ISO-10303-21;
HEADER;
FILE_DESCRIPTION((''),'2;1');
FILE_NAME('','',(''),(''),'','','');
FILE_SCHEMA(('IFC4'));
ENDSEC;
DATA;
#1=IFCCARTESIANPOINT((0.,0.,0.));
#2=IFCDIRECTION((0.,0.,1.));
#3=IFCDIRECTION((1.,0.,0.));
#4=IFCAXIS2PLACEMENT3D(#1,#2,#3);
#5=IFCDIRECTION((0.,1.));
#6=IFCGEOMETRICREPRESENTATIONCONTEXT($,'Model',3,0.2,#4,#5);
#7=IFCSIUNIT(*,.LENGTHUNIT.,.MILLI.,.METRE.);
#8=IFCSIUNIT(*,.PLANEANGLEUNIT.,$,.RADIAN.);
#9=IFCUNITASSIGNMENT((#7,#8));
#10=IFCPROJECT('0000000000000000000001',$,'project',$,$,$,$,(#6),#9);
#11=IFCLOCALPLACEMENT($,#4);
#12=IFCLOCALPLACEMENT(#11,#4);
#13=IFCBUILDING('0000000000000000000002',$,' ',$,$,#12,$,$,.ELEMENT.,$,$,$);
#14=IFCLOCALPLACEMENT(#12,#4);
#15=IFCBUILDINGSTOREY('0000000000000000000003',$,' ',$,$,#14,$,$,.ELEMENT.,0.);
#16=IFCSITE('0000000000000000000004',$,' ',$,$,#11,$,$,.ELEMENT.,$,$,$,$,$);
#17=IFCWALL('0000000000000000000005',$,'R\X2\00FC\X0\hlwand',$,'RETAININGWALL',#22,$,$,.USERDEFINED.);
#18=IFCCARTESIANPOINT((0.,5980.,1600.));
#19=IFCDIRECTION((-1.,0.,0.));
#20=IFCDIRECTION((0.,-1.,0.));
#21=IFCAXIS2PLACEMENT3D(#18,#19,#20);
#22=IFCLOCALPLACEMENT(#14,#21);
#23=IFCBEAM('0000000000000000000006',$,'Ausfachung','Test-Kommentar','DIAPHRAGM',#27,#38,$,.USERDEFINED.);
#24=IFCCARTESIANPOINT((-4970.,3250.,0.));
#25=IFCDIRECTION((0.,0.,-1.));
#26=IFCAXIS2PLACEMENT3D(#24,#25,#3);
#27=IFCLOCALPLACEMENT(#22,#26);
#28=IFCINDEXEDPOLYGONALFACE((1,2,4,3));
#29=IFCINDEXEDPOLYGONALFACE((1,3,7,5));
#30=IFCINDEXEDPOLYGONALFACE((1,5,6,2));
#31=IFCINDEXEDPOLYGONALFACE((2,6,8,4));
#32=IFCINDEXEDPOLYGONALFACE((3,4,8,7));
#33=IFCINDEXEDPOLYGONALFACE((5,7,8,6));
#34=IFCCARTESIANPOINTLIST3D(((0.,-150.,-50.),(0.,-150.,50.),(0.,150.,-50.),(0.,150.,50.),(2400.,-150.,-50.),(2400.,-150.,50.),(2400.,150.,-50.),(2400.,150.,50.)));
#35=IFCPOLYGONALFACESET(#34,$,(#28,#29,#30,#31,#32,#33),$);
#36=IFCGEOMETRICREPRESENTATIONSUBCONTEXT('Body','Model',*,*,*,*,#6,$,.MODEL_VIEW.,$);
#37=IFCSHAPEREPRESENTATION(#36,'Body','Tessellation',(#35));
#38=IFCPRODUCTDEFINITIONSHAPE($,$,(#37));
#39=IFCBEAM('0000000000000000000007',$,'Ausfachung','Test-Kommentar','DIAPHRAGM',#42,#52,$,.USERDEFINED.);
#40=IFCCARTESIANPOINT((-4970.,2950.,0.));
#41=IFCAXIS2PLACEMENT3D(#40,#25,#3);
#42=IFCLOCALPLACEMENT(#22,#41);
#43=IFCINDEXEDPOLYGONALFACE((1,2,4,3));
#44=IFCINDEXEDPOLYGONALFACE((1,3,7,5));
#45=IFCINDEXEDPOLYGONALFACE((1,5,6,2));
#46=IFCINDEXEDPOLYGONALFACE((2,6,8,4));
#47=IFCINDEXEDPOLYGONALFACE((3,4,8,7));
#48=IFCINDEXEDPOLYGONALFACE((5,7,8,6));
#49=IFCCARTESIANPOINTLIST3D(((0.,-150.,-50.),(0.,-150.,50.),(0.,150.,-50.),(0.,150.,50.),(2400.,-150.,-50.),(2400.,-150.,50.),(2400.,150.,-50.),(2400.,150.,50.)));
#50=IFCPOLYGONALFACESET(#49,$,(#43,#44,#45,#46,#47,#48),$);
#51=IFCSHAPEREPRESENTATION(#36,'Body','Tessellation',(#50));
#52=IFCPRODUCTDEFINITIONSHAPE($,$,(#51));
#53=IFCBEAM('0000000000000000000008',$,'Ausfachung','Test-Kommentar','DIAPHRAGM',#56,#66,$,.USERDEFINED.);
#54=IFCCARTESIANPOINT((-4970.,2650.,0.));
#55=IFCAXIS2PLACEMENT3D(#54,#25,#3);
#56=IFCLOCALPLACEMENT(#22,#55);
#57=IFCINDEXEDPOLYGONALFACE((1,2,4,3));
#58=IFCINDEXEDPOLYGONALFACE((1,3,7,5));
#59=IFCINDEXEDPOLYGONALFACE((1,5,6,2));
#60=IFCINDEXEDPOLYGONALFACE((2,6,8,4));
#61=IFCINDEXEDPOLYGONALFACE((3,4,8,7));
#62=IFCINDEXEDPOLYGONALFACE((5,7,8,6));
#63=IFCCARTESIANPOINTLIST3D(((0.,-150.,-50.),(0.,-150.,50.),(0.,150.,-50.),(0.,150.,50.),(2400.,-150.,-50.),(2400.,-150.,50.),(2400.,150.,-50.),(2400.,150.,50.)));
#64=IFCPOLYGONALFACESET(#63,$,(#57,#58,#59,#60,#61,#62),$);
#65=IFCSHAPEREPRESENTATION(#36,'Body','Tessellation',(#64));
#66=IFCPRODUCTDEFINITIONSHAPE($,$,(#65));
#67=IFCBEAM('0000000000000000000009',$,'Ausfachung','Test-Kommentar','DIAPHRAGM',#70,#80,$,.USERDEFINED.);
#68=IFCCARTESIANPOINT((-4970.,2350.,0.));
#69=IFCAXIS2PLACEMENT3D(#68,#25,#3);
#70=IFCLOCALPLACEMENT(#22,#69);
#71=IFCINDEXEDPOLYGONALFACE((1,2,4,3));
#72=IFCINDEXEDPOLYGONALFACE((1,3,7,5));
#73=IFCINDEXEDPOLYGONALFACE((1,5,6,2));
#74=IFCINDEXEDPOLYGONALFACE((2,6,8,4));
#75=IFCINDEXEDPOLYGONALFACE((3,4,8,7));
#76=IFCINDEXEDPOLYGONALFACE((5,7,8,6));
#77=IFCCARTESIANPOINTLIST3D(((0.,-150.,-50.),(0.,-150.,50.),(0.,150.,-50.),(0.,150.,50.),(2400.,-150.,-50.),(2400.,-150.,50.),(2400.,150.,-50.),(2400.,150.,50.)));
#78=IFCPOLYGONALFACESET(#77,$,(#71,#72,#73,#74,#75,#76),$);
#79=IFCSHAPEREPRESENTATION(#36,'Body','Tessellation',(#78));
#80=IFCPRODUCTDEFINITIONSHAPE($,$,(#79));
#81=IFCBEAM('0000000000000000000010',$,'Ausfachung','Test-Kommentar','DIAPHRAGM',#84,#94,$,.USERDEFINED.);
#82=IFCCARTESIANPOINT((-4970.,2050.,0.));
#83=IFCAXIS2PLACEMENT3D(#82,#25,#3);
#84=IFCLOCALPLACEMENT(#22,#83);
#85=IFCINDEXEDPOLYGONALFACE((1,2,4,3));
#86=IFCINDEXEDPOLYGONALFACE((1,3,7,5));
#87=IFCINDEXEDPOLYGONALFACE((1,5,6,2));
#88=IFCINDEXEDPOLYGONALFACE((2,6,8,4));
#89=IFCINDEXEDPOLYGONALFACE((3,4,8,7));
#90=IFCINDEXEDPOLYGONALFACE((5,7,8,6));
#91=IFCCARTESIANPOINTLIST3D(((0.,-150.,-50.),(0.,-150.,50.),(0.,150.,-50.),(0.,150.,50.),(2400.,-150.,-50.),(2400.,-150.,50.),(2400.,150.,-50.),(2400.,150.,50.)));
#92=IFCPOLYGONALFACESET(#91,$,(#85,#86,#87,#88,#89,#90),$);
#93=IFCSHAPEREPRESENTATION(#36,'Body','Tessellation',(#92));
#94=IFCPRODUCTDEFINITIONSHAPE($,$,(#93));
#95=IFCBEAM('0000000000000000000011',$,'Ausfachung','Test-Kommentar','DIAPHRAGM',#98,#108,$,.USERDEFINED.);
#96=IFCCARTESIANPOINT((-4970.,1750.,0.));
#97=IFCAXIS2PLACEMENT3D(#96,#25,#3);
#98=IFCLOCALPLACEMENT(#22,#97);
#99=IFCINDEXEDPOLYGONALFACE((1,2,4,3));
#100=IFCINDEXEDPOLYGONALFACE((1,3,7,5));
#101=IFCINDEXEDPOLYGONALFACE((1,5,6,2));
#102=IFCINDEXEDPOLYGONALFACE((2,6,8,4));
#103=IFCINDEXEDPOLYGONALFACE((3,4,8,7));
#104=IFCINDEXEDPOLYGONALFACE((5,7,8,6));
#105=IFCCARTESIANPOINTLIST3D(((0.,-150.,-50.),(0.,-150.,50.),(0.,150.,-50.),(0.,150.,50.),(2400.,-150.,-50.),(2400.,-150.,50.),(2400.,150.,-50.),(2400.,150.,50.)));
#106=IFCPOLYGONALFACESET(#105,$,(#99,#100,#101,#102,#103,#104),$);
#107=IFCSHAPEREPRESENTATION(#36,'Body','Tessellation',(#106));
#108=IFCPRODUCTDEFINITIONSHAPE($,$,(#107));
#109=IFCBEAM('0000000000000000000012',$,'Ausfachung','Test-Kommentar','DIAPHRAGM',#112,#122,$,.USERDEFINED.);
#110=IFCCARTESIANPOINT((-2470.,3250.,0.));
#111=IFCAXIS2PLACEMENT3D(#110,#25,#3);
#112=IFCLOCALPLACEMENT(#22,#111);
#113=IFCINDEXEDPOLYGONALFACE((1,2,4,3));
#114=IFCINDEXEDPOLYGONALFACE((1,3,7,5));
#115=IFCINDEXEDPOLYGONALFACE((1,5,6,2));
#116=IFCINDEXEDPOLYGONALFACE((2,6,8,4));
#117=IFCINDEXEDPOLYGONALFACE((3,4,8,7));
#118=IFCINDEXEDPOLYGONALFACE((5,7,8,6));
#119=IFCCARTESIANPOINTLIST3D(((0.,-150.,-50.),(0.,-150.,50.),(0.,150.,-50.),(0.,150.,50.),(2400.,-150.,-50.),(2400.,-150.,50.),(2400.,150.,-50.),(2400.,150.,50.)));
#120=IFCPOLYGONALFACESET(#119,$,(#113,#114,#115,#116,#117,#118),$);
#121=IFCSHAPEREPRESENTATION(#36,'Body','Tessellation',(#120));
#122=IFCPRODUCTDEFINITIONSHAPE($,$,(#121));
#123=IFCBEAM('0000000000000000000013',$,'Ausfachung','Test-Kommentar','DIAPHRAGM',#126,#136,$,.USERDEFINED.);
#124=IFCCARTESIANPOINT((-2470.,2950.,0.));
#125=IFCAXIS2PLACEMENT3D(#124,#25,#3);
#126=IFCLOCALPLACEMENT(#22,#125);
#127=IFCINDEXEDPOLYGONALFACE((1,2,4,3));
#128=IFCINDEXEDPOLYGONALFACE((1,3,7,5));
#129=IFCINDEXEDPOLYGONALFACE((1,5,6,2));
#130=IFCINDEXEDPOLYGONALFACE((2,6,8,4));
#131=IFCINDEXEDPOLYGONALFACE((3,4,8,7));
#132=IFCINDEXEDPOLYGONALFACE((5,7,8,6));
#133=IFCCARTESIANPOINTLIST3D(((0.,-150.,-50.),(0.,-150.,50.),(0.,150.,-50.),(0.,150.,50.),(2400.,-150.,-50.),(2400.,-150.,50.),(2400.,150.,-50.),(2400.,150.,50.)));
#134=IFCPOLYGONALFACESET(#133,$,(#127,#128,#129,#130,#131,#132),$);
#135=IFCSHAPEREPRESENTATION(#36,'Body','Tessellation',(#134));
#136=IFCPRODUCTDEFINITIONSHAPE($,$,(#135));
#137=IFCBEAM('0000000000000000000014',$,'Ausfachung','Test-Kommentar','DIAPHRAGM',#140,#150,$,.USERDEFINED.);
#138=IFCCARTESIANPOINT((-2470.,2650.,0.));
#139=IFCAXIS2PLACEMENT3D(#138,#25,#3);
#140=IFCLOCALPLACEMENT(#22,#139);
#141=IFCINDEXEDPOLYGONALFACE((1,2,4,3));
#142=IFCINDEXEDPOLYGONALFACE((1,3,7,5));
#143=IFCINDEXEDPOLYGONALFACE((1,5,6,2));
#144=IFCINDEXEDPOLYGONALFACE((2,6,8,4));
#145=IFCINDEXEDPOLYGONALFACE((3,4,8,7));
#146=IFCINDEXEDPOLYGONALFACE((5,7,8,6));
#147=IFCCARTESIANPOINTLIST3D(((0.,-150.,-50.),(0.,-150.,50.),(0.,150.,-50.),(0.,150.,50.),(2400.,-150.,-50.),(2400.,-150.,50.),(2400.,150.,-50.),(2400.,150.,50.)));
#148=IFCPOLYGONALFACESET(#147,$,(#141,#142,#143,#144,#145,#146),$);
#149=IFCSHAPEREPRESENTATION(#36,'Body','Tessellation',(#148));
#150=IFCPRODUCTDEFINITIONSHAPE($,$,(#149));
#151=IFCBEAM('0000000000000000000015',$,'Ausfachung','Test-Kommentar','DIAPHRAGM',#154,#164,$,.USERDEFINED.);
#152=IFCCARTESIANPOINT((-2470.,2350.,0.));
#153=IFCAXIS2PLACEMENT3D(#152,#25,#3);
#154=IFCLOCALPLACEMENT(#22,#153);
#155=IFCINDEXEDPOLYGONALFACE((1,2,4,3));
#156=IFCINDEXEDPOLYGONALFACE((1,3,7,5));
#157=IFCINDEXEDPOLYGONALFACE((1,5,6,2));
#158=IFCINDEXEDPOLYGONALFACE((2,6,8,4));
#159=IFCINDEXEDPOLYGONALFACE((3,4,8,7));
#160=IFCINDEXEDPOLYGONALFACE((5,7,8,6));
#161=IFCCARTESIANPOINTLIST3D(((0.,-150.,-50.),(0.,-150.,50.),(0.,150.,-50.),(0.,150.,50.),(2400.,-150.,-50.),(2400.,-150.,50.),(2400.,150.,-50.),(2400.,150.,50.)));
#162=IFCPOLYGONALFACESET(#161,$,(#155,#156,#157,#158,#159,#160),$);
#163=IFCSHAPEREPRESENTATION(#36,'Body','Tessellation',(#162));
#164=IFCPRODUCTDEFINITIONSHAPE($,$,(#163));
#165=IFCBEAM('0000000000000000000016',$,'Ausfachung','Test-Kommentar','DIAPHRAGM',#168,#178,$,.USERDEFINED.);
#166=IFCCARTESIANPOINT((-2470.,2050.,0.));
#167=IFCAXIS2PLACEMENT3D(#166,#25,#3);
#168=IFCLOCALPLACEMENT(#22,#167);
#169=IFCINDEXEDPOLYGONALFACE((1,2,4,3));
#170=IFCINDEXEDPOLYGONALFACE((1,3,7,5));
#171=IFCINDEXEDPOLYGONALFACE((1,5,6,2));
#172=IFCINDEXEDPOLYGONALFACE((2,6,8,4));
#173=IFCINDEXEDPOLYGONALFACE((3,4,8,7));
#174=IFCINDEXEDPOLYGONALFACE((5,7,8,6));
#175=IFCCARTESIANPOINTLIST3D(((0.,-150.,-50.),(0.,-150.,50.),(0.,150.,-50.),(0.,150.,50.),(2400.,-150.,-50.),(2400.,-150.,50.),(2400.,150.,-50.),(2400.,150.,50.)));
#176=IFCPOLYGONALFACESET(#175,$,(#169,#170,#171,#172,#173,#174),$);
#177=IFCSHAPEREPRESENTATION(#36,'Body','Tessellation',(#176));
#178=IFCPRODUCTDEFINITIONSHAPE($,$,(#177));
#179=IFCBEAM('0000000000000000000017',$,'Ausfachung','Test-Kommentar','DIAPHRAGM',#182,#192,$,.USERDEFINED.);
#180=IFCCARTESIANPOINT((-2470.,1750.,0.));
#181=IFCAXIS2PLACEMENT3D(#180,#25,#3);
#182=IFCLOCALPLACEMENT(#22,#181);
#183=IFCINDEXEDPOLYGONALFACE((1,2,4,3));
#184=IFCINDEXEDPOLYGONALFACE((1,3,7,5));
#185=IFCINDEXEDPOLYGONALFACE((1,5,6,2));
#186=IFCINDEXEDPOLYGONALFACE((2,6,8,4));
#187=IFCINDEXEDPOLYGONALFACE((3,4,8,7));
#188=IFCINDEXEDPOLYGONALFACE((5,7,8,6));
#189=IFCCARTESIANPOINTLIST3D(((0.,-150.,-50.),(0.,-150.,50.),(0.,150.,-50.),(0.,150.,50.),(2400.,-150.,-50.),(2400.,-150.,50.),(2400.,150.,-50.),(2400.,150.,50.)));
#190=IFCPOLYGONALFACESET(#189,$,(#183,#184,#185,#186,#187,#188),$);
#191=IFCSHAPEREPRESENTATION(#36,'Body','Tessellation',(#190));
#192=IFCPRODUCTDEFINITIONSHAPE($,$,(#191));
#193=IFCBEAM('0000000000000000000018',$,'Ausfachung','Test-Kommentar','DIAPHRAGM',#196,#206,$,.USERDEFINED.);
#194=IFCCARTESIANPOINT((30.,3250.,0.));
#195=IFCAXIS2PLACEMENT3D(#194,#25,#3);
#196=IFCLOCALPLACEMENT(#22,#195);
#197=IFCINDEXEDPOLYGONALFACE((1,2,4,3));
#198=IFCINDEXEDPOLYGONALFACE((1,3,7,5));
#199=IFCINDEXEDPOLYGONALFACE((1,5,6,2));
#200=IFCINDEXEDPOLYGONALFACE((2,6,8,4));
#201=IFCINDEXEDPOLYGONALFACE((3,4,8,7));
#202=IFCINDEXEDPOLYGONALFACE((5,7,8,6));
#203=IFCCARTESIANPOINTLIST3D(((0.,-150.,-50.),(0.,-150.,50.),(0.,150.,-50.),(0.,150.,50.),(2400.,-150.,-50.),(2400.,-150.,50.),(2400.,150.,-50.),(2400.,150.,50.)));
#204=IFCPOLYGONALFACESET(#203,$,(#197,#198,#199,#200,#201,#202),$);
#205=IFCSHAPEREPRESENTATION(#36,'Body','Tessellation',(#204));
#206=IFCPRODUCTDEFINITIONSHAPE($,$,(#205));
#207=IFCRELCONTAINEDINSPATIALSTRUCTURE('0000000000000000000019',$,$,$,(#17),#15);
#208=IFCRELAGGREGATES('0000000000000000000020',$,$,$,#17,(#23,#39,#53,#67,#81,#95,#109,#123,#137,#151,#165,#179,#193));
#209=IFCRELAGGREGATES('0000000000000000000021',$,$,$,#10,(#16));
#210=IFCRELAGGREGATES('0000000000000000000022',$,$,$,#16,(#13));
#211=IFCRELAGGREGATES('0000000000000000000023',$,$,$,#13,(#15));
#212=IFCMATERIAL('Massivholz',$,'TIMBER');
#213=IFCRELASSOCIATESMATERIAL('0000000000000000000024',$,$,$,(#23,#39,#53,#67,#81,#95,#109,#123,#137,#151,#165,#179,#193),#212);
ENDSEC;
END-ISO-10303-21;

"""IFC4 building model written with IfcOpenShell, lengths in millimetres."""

from ifc_helpers import new_model, si_unit, direction, frame, origin_with_axes, place, context, subcontext, project, spatial, line, indexed_curve, outline, extrude, material, element, aggregate, save


model = new_model("IFC4")

# Units and contexts
model_context = context("Model", 3, precision=0.2, world=origin_with_axes(), true_north=direction((0.0, 1.0)))
body_context = subcontext(model_context, "Body", "Model", "MODEL_VIEW")
ifc_project = project(units=[si_unit("LENGTHUNIT", "METRE", prefix="MILLI"), si_unit("PLANEANGLEUNIT", "RADIAN")], contexts=[model_context])

# Site, building, storey
site_placement = place(None, origin_with_axes())
site = spatial("IfcSite", under=ifc_project, at=site_placement, Name=" ", CompositionType="ELEMENT")
building_placement = place(site_placement, origin_with_axes())
building = spatial("IfcBuilding", under=site, at=building_placement, Name=" ", CompositionType="ELEMENT")
storey_placement = place(building_placement, origin_with_axes())
storey = spatial("IfcBuildingStorey", under=building, at=storey_placement, Name=" ", CompositionType="ELEMENT", Elevation=0.0)

# Wall, beams
wall_1_placement = place(storey_placement, frame((0.0, 5980.0, 1600.0), z_axis=(-1.0, 0.0, 0.0), x_axis=(0.0, -1.0, 0.0)))
wall_1 = element("IfcWall", 1, at=wall_1_placement, inside=storey, Name="Rühlwand", ObjectType="RETAININGWALL", PredefinedType="USERDEFINED")
ifc_material_1 = material(Name="Massivholz", Category="TIMBER")
beam_1_placement = place(wall_1_placement, frame((-4970.0, 3250.0, 0.0), z_axis=(0.0, 0.0, -1.0), x_axis=(1.0, 0.0, 0.0)))
beam_1 = element("IfcBeam", 2, at=beam_1_placement, material=ifc_material_1, Name="Ausfachung", Description="Test-Kommentar", ObjectType="DIAPHRAGM", PredefinedType="USERDEFINED", context=body_context, shape_type="SolidModel", body=[
    extrude(outline(indexed_curve([(-50.0, -150.0), (50.0, -150.0), (50.0, 150.0), (-50.0, 150.0)], segments=[line(1, 2, 3, 4, 1)])), frame((0.0, 0.0, 0.0), z_axis=(-1.0, 0.0, 0.0), x_axis=(0.0, 0.0, 1.0)), (0.0, 0.0, -1.0), 2400.0),
])
beam_2_placement = place(wall_1_placement, frame((-4970.0, 2950.0, 0.0), z_axis=(0.0, 0.0, -1.0), x_axis=(1.0, 0.0, 0.0)))
beam_2 = element("IfcBeam", 3, at=beam_2_placement, material=ifc_material_1, Name="Ausfachung", Description="Test-Kommentar", ObjectType="DIAPHRAGM", PredefinedType="USERDEFINED", context=body_context, shape_type="SolidModel", body=[
    extrude(outline(indexed_curve([(-50.0, -150.0), (50.0, -150.0), (50.0, 150.0), (-50.0, 150.0)], segments=[line(1, 2, 3, 4, 1)])), frame((0.0, 0.0, 0.0), z_axis=(-1.0, 0.0, 0.0), x_axis=(0.0, 0.0, 1.0)), (0.0, 0.0, -1.0), 2400.0),
])
beam_3_placement = place(wall_1_placement, frame((-4970.0, 2650.0, 0.0), z_axis=(0.0, 0.0, -1.0), x_axis=(1.0, 0.0, 0.0)))
beam_3 = element("IfcBeam", 4, at=beam_3_placement, material=ifc_material_1, Name="Ausfachung", Description="Test-Kommentar", ObjectType="DIAPHRAGM", PredefinedType="USERDEFINED", context=body_context, shape_type="SolidModel", body=[
    extrude(outline(indexed_curve([(-50.0, -150.0), (50.0, -150.0), (50.0, 150.0), (-50.0, 150.0)], segments=[line(1, 2, 3, 4, 1)])), frame((0.0, 0.0, 0.0), z_axis=(-1.0, 0.0, 0.0), x_axis=(0.0, 0.0, 1.0)), (0.0, 0.0, -1.0), 2400.0),
])
beam_4_placement = place(wall_1_placement, frame((-4970.0, 2350.0, 0.0), z_axis=(0.0, 0.0, -1.0), x_axis=(1.0, 0.0, 0.0)))
beam_4 = element("IfcBeam", 5, at=beam_4_placement, material=ifc_material_1, Name="Ausfachung", Description="Test-Kommentar", ObjectType="DIAPHRAGM", PredefinedType="USERDEFINED", context=body_context, shape_type="SolidModel", body=[
    extrude(outline(indexed_curve([(-50.0, -150.0), (50.0, -150.0), (50.0, 150.0), (-50.0, 150.0)], segments=[line(1, 2, 3, 4, 1)])), frame((0.0, 0.0, 0.0), z_axis=(-1.0, 0.0, 0.0), x_axis=(0.0, 0.0, 1.0)), (0.0, 0.0, -1.0), 2400.0),
])
beam_5_placement = place(wall_1_placement, frame((-4970.0, 2050.0, 0.0), z_axis=(0.0, 0.0, -1.0), x_axis=(1.0, 0.0, 0.0)))
beam_5 = element("IfcBeam", 6, at=beam_5_placement, material=ifc_material_1, Name="Ausfachung", Description="Test-Kommentar", ObjectType="DIAPHRAGM", PredefinedType="USERDEFINED", context=body_context, shape_type="SolidModel", body=[
    extrude(outline(indexed_curve([(-50.0, -150.0), (50.0, -150.0), (50.0, 150.0), (-50.0, 150.0)], segments=[line(1, 2, 3, 4, 1)])), frame((0.0, 0.0, 0.0), z_axis=(-1.0, 0.0, 0.0), x_axis=(0.0, 0.0, 1.0)), (0.0, 0.0, -1.0), 2400.0),
])
beam_6_placement = place(wall_1_placement, frame((-4970.0, 1750.0, 0.0), z_axis=(0.0, 0.0, -1.0), x_axis=(1.0, 0.0, 0.0)))
beam_6 = element("IfcBeam", 7, at=beam_6_placement, material=ifc_material_1, Name="Ausfachung", Description="Test-Kommentar", ObjectType="DIAPHRAGM", PredefinedType="USERDEFINED", context=body_context, shape_type="SolidModel", body=[
    extrude(outline(indexed_curve([(-50.0, -150.0), (50.0, -150.0), (50.0, 150.0), (-50.0, 150.0)], segments=[line(1, 2, 3, 4, 1)])), frame((0.0, 0.0, 0.0), z_axis=(-1.0, 0.0, 0.0), x_axis=(0.0, 0.0, 1.0)), (0.0, 0.0, -1.0), 2400.0),
])
beam_7_placement = place(wall_1_placement, frame((-2470.0, 3250.0, 0.0), z_axis=(0.0, 0.0, -1.0), x_axis=(1.0, 0.0, 0.0)))
beam_7 = element("IfcBeam", 8, at=beam_7_placement, material=ifc_material_1, Name="Ausfachung", Description="Test-Kommentar", ObjectType="DIAPHRAGM", PredefinedType="USERDEFINED", context=body_context, shape_type="SolidModel", body=[
    extrude(outline(indexed_curve([(-50.0, -150.0), (50.0, -150.0), (50.0, 150.0), (-50.0, 150.0)], segments=[line(1, 2, 3, 4, 1)])), frame((0.0, 0.0, 0.0), z_axis=(-1.0, 0.0, 0.0), x_axis=(0.0, 0.0, 1.0)), (0.0, 0.0, -1.0), 2400.0),
])
beam_8_placement = place(wall_1_placement, frame((-2470.0, 2950.0, 0.0), z_axis=(0.0, 0.0, -1.0), x_axis=(1.0, 0.0, 0.0)))
beam_8 = element("IfcBeam", 9, at=beam_8_placement, material=ifc_material_1, Name="Ausfachung", Description="Test-Kommentar", ObjectType="DIAPHRAGM", PredefinedType="USERDEFINED", context=body_context, shape_type="SolidModel", body=[
    extrude(outline(indexed_curve([(-50.0, -150.0), (50.0, -150.0), (50.0, 150.0), (-50.0, 150.0)], segments=[line(1, 2, 3, 4, 1)])), frame((0.0, 0.0, 0.0), z_axis=(-1.0, 0.0, 0.0), x_axis=(0.0, 0.0, 1.0)), (0.0, 0.0, -1.0), 2400.0),
])
beam_9_placement = place(wall_1_placement, frame((-2470.0, 2650.0, 0.0), z_axis=(0.0, 0.0, -1.0), x_axis=(1.0, 0.0, 0.0)))
beam_9 = element("IfcBeam", 10, at=beam_9_placement, material=ifc_material_1, Name="Ausfachung", Description="Test-Kommentar", ObjectType="DIAPHRAGM", PredefinedType="USERDEFINED", context=body_context, shape_type="SolidModel", body=[
    extrude(outline(indexed_curve([(-50.0, -150.0), (50.0, -150.0), (50.0, 150.0), (-50.0, 150.0)], segments=[line(1, 2, 3, 4, 1)])), frame((0.0, 0.0, 0.0), z_axis=(-1.0, 0.0, 0.0), x_axis=(0.0, 0.0, 1.0)), (0.0, 0.0, -1.0), 2400.0),
])
beam_10_placement = place(wall_1_placement, frame((-2470.0, 2350.0, 0.0), z_axis=(0.0, 0.0, -1.0), x_axis=(1.0, 0.0, 0.0)))
beam_10 = element("IfcBeam", 11, at=beam_10_placement, material=ifc_material_1, Name="Ausfachung", Description="Test-Kommentar", ObjectType="DIAPHRAGM", PredefinedType="USERDEFINED", context=body_context, shape_type="SolidModel", body=[
    extrude(outline(indexed_curve([(-50.0, -150.0), (50.0, -150.0), (50.0, 150.0), (-50.0, 150.0)], segments=[line(1, 2, 3, 4, 1)])), frame((0.0, 0.0, 0.0), z_axis=(-1.0, 0.0, 0.0), x_axis=(0.0, 0.0, 1.0)), (0.0, 0.0, -1.0), 2400.0),
])
beam_11_placement = place(wall_1_placement, frame((-2470.0, 2050.0, 0.0), z_axis=(0.0, 0.0, -1.0), x_axis=(1.0, 0.0, 0.0)))
beam_11 = element("IfcBeam", 12, at=beam_11_placement, material=ifc_material_1, Name="Ausfachung", Description="Test-Kommentar", ObjectType="DIAPHRAGM", PredefinedType="USERDEFINED", context=body_context, shape_type="SolidModel", body=[
    extrude(outline(indexed_curve([(-50.0, -150.0), (50.0, -150.0), (50.0, 150.0), (-50.0, 150.0)], segments=[line(1, 2, 3, 4, 1)])), frame((0.0, 0.0, 0.0), z_axis=(-1.0, 0.0, 0.0), x_axis=(0.0, 0.0, 1.0)), (0.0, 0.0, -1.0), 2400.0),
])
beam_12_placement = place(wall_1_placement, frame((-2470.0, 1750.0, 0.0), z_axis=(0.0, 0.0, -1.0), x_axis=(1.0, 0.0, 0.0)))
beam_12 = element("IfcBeam", 13, at=beam_12_placement, material=ifc_material_1, Name="Ausfachung", Description="Test-Kommentar", ObjectType="DIAPHRAGM", PredefinedType="USERDEFINED", context=body_context, shape_type="SolidModel", body=[
    extrude(outline(indexed_curve([(-50.0, -150.0), (50.0, -150.0), (50.0, 150.0), (-50.0, 150.0)], segments=[line(1, 2, 3, 4, 1)])), frame((0.0, 0.0, 0.0), z_axis=(-1.0, 0.0, 0.0), x_axis=(0.0, 0.0, 1.0)), (0.0, 0.0, -1.0), 2400.0),
])
beam_13_placement = place(wall_1_placement, frame((30.0, 3250.0, 0.0), z_axis=(0.0, 0.0, -1.0), x_axis=(1.0, 0.0, 0.0)))
beam_13 = element("IfcBeam", 14, at=beam_13_placement, material=ifc_material_1, Name="Ausfachung", Description="Test-Kommentar", ObjectType="DIAPHRAGM", PredefinedType="USERDEFINED", context=body_context, shape_type="SolidModel", body=[
    extrude(outline(indexed_curve([(-50.0, -150.0), (50.0, -150.0), (50.0, 150.0), (-50.0, 150.0)], segments=[line(1, 2, 3, 4, 1)])), frame((0.0, 0.0, 0.0), z_axis=(-1.0, 0.0, 0.0), x_axis=(0.0, 0.0, 1.0)), (0.0, 0.0, -1.0), 2400.0),
])

aggregate(wall_1, [beam_1, beam_2, beam_3, beam_4, beam_5, beam_6, beam_7, beam_8, beam_9, beam_10, beam_11, beam_12, beam_13])

save(model, "model.ifc")
